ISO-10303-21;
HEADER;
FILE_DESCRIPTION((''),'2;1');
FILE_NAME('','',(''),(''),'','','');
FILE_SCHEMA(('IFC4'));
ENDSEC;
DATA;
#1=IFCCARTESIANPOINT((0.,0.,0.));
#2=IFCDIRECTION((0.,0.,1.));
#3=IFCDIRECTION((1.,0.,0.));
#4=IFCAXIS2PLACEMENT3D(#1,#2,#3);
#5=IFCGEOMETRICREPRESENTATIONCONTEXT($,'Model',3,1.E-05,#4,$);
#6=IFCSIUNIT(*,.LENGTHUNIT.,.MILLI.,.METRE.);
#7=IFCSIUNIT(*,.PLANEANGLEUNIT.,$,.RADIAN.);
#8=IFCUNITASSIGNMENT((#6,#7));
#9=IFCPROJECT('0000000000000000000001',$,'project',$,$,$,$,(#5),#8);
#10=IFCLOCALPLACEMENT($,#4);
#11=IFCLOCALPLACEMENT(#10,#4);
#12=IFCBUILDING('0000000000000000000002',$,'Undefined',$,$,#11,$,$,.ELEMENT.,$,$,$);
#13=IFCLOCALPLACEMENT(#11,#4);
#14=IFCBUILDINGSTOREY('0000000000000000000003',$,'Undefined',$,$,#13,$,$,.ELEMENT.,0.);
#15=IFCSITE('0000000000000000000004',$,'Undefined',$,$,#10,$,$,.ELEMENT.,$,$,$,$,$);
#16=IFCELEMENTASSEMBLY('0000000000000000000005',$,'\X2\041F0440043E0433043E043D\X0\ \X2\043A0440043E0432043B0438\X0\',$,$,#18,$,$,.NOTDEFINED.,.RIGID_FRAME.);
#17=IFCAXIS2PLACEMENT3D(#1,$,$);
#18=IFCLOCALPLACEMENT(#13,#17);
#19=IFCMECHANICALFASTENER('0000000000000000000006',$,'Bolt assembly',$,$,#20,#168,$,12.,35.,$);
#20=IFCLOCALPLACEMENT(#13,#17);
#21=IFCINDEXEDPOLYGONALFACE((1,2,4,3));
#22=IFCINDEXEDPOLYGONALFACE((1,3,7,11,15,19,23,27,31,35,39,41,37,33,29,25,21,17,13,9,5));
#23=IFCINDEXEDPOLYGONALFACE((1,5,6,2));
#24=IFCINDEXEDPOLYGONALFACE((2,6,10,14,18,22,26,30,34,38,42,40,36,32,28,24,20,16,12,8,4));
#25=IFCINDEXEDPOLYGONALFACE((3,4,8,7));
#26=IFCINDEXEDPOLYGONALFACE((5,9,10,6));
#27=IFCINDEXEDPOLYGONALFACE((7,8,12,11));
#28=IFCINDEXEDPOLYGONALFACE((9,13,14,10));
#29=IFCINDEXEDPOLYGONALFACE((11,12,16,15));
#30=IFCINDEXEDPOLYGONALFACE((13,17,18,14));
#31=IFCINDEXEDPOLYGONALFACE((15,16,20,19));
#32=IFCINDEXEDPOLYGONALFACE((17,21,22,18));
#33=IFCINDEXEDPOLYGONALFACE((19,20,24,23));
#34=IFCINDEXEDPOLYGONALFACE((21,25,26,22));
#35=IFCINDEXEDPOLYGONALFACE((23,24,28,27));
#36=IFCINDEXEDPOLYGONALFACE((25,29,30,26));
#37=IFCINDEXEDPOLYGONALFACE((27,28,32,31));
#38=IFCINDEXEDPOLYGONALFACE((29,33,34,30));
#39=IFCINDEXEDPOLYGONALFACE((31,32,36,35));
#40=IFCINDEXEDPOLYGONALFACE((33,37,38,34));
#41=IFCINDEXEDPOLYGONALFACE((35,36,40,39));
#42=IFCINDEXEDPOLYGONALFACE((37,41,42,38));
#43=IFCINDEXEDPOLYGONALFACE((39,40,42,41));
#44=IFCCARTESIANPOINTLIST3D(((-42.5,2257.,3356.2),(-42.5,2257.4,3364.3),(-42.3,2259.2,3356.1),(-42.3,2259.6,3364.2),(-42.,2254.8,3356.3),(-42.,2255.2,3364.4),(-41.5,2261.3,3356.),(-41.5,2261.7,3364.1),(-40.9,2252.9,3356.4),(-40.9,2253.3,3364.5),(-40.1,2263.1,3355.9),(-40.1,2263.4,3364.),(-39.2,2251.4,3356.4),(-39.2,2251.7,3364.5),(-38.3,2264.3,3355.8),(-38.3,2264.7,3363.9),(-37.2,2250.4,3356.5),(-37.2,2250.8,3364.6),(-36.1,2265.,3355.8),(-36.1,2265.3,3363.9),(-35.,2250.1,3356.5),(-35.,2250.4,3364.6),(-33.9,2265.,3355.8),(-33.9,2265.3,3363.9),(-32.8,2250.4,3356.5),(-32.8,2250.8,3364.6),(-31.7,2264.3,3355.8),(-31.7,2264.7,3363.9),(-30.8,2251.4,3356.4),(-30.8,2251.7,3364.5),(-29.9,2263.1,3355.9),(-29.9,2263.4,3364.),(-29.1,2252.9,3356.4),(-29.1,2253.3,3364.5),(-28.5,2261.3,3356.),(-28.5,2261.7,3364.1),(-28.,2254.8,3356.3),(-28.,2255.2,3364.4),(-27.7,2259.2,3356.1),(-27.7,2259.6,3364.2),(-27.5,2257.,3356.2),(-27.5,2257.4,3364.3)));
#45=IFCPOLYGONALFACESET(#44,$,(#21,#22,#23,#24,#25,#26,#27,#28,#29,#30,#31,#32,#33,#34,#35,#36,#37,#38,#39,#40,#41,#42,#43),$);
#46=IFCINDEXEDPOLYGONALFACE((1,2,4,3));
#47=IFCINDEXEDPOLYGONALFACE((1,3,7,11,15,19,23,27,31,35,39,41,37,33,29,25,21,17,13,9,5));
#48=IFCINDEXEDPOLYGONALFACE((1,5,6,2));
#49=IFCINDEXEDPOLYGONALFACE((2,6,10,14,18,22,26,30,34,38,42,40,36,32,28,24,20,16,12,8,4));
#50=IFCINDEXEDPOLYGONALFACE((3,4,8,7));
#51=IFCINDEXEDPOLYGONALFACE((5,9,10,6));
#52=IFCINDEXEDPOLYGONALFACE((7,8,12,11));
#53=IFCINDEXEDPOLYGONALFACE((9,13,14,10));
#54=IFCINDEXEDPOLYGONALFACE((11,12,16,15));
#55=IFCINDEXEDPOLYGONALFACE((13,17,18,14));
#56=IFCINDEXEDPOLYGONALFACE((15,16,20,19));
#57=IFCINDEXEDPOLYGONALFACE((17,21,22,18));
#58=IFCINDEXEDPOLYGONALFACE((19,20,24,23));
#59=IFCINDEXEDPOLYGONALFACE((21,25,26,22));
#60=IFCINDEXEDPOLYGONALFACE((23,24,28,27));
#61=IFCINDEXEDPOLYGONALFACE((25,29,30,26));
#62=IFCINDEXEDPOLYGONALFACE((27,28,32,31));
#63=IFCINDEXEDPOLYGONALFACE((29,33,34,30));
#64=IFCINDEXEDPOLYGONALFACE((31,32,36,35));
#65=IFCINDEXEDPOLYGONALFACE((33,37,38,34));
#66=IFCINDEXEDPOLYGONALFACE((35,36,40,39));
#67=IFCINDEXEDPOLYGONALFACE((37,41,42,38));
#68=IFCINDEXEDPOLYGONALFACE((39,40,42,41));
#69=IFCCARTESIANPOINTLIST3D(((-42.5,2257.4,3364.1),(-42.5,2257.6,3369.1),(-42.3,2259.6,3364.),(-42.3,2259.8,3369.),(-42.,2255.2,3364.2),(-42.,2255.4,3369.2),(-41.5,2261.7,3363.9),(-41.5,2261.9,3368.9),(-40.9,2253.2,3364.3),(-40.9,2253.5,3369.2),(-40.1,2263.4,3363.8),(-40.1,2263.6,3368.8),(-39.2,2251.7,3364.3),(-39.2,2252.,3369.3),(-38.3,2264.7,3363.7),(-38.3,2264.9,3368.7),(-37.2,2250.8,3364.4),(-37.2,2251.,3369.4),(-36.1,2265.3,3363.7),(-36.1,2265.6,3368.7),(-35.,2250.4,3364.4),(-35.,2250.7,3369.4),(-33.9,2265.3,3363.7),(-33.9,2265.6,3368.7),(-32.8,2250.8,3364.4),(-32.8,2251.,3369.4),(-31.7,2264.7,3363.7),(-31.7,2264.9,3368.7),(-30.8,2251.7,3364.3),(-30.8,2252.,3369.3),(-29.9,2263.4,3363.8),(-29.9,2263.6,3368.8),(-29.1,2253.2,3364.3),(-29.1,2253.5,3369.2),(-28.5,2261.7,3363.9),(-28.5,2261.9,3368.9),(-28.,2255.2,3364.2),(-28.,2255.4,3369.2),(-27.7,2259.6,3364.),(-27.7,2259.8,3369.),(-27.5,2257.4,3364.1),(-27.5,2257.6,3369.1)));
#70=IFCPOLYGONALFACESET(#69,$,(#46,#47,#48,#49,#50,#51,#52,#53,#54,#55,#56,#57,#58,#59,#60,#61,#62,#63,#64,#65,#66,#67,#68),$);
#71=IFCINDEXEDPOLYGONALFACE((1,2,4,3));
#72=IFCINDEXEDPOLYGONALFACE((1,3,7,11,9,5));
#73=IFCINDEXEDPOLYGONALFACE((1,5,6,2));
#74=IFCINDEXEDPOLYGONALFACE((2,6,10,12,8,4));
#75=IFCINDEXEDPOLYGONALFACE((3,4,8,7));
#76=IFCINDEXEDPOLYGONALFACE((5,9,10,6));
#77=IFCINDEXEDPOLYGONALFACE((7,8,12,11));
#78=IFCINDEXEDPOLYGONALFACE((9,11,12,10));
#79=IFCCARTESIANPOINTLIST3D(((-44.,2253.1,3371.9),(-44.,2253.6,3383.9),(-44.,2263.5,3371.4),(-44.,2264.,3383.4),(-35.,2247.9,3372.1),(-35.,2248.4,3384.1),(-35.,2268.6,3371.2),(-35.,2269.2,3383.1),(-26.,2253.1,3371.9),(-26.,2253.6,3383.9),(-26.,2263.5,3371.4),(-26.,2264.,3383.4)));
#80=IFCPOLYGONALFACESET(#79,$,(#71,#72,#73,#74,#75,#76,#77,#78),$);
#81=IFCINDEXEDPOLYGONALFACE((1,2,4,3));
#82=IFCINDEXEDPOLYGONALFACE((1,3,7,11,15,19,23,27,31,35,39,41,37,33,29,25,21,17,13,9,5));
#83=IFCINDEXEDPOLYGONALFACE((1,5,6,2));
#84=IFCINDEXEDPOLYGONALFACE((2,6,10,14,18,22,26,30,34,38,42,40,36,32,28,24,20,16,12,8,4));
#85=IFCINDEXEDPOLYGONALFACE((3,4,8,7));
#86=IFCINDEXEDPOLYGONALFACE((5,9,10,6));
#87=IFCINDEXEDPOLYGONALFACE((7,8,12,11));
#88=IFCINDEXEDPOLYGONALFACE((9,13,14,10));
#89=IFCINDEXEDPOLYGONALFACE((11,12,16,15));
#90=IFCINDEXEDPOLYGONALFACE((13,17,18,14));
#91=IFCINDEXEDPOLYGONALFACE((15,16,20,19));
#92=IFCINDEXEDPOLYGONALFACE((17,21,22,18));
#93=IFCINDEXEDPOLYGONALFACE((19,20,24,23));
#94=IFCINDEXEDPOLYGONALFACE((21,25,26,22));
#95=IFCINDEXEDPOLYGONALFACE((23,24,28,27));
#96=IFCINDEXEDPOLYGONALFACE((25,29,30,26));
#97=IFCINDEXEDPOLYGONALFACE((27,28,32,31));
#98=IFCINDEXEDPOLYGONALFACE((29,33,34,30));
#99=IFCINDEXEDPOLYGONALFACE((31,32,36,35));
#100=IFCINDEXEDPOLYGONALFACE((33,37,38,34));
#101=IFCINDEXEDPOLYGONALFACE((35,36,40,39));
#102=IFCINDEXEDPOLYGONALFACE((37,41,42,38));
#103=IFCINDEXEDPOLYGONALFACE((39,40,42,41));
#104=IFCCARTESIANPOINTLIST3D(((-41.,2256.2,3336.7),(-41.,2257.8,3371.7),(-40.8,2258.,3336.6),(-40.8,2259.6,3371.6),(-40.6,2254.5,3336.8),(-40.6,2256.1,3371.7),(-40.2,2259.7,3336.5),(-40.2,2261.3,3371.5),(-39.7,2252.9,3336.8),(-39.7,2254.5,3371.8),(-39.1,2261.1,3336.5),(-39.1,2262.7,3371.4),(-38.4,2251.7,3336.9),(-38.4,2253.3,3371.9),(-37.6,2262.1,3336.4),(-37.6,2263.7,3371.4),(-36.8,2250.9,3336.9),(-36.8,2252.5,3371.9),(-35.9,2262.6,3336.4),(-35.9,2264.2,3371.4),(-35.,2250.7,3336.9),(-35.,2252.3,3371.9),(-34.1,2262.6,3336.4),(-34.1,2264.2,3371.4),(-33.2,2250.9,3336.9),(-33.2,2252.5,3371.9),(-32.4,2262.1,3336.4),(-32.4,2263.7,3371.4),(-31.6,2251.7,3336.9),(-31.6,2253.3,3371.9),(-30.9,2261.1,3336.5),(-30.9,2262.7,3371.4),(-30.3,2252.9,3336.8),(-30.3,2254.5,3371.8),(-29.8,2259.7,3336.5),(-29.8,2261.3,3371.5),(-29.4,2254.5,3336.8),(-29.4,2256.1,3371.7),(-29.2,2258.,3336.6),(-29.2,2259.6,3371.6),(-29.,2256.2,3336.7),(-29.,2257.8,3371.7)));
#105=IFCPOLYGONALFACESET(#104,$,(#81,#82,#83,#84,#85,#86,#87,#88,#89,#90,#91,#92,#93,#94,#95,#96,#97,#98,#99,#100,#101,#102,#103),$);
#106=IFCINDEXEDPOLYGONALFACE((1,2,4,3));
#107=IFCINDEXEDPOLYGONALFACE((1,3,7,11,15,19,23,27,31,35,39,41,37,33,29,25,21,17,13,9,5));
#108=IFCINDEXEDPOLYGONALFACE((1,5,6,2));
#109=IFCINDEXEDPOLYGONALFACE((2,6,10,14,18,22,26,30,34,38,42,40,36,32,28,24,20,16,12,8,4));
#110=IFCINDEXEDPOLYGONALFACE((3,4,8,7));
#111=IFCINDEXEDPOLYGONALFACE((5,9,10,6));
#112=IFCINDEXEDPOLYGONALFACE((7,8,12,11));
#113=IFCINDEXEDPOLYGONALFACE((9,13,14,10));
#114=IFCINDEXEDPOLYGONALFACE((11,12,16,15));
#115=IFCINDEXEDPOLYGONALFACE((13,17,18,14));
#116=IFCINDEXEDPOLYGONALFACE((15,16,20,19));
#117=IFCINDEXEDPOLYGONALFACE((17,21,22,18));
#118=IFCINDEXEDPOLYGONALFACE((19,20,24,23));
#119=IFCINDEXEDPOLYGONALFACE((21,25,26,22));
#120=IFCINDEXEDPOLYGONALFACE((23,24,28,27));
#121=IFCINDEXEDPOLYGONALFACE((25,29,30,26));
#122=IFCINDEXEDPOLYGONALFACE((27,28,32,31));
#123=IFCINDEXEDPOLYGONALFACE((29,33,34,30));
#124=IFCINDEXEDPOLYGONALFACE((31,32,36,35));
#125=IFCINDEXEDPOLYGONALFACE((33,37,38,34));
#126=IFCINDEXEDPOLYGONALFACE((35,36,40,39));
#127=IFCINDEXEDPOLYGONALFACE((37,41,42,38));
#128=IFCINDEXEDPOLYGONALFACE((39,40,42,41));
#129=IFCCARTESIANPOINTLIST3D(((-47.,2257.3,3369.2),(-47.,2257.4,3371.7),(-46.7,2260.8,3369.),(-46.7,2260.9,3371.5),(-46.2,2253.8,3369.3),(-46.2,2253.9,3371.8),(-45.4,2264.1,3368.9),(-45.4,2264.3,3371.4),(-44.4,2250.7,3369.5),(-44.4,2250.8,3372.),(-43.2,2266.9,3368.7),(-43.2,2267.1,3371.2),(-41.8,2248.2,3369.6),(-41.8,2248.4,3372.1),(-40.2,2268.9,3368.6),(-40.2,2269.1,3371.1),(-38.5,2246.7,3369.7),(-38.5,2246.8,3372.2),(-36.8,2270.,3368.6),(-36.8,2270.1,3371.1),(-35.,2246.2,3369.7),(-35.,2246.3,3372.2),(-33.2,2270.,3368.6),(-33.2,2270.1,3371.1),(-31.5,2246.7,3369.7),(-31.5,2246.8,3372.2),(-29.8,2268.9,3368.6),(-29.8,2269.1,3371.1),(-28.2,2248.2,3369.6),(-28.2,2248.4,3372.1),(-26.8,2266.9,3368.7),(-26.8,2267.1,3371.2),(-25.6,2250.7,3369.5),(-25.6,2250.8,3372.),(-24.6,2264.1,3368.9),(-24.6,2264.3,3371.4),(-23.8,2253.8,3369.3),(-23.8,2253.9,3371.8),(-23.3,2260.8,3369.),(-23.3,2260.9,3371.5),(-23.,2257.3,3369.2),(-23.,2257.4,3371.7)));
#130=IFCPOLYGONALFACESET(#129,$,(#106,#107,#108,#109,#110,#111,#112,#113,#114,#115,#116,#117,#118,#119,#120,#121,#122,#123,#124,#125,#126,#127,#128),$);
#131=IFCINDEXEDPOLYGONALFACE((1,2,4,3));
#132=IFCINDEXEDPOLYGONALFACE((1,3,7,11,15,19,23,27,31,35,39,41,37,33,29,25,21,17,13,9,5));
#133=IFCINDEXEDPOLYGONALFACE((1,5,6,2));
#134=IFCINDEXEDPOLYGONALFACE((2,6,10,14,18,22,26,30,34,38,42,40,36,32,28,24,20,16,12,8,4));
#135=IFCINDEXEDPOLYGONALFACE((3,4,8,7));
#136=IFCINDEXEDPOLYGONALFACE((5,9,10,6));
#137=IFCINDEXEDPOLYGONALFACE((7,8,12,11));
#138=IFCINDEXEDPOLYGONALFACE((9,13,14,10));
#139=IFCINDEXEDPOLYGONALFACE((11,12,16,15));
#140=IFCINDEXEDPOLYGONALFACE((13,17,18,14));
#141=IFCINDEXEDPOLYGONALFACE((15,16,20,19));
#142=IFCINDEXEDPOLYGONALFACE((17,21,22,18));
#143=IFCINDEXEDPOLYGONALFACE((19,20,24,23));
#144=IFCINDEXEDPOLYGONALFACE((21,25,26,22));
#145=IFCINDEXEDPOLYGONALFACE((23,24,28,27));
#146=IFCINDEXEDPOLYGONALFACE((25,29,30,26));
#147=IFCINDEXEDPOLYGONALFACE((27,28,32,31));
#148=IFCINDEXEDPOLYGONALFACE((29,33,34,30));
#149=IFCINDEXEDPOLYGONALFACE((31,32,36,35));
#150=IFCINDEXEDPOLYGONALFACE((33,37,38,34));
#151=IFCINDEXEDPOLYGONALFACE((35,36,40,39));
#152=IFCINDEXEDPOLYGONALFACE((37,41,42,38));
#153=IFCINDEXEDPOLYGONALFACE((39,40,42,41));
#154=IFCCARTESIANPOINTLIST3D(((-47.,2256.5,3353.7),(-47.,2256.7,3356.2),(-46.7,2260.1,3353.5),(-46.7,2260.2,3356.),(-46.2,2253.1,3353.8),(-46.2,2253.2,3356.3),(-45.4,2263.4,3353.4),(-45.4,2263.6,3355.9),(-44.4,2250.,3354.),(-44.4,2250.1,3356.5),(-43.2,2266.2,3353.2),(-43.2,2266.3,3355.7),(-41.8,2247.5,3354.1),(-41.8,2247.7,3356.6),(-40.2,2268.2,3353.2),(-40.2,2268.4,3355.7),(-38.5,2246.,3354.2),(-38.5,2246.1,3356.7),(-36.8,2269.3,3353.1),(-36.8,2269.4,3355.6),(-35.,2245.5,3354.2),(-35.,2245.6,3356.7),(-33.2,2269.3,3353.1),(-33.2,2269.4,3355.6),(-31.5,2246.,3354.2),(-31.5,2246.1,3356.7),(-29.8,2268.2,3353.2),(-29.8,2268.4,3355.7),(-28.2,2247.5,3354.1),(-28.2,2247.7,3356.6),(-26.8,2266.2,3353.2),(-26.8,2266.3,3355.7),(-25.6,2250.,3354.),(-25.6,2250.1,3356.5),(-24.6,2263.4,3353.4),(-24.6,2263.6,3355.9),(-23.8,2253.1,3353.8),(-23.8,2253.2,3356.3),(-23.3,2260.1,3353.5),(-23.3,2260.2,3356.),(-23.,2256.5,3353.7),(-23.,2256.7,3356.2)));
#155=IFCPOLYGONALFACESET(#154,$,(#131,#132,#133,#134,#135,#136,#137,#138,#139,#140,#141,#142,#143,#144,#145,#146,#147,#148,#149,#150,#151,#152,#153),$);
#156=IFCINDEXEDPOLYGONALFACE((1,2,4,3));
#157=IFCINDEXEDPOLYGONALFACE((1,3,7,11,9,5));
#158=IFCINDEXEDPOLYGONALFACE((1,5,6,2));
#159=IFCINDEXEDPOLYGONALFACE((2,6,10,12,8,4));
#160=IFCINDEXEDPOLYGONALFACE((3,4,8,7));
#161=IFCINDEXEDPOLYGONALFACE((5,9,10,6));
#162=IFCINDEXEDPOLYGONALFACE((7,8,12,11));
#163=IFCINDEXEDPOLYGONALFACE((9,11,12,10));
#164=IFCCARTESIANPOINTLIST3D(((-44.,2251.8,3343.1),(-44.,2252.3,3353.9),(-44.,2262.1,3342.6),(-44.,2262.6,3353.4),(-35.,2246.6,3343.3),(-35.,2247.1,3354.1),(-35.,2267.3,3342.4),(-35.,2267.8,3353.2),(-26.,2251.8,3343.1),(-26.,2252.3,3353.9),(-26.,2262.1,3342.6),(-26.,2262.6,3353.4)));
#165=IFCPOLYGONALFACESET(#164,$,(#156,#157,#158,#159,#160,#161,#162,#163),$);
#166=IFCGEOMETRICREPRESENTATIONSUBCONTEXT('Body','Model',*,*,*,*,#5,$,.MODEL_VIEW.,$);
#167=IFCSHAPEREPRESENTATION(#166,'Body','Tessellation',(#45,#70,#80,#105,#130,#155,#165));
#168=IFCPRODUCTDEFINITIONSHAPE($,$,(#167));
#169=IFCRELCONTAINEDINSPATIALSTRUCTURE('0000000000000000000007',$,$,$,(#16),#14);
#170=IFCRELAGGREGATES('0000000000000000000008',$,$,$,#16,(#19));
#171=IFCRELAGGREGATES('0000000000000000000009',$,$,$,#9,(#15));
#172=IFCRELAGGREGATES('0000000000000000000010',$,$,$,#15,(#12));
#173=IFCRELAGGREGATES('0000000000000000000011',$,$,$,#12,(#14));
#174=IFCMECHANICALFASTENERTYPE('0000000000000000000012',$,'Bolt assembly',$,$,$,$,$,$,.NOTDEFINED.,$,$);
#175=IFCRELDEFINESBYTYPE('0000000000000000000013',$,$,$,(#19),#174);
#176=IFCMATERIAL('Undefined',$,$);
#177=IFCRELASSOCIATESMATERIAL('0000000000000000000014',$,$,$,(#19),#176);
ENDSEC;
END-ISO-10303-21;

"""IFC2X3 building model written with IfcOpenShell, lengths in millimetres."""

from ifc_helpers import new_model, si_unit, frame, origin_with_axes, origin_2d_with_axis, place, context, subcontext, project, spatial, polyline, circle, outline, extrude, source, transform, mapped, material, type_object, element, aggregate, save


model = new_model("IFC2X3")

# Units and contexts
model_context = context("Model", 3, precision=1e-05, world=origin_with_axes())
body_context = subcontext(model_context, "Body", "Model", "MODEL_VIEW")
ifc_project = project(units=[si_unit("LENGTHUNIT", "METRE", prefix="MILLI"), si_unit("PLANEANGLEUNIT", "RADIAN")], contexts=[model_context])

# Site, building, storey
site_placement = place(None, origin_with_axes())
site = spatial("IfcSite", under=ifc_project, at=site_placement, Name="Undefined", CompositionType="ELEMENT")
building_placement = place(site_placement, origin_with_axes())
building = spatial("IfcBuilding", under=site, at=building_placement, Name="Undefined", CompositionType="ELEMENT")
storey_placement = place(building_placement, origin_with_axes())
storey = spatial("IfcBuildingStorey", under=building, at=storey_placement, Name="Undefined", CompositionType="ELEMENT", Elevation=0.0)

# Element assembly
assembly_1_placement = place(storey_placement, origin_with_axes())
assembly_1 = element("IfcElementAssembly", 1, at=assembly_1_placement, inside=storey, Name="Прогон кровли", AssemblyPlace="NOTDEFINED", PredefinedType="RIGID_FRAME")

# Mechanical fastener
ifc_material_1 = material(Name="Undefined")
mechanical_fastener_type = type_object("IfcMechanicalFastenerType", Name="Bolt assembly")
shared_shape_1 = source(origin_with_axes(), body_context, "Body", "SweptSolid", [
    extrude(circle(Radius=7.5, at=origin_2d_with_axis()), frame((0.0, -0.1, 0.0), z_axis=(0.0, 1.0, 0.0), x_axis=(1.0, 0.0, 0.0)), (0.0, 0.0, 1.0), 8.1),
    extrude(circle(Radius=7.5, at=origin_2d_with_axis()), frame((0.0, -4.9, 0.0), z_axis=(0.0, 1.0, 0.0), x_axis=(1.0, 0.0, 0.0)), (0.0, 0.0, 1.0), 5.0),
    extrude(outline(polyline([(10.4, 0.0), (5.2, 9.0), (-5.2, 9.0), (-10.4, 0.0), (-5.2, -9.0), (5.2, -9.0), (10.4, 0.0)])), frame((0.0, -19.5, 0.0), z_axis=(0.0, 1.0, 0.0), x_axis=(1.0, 0.0, 0.0)), (0.0, 0.0, 1.0), 12.0),
    extrude(circle(Radius=6.0, at=origin_2d_with_axis()), frame((0.0, -7.5, 0.0), z_axis=(0.0, 1.0, 0.0), x_axis=(1.0, 0.0, 0.0)), (0.0, 0.0, 1.0), 35.0),
    extrude(circle(Radius=12.0, at=origin_2d_with_axis()), frame((0.0, -7.5, 0.0), z_axis=(0.0, 1.0, 0.0), x_axis=(1.0, 0.0, 0.0)), (0.0, 0.0, 1.0), 2.5),
    extrude(circle(Radius=12.0, at=origin_2d_with_axis()), frame((0.0, 8.0, 0.0), z_axis=(0.0, 1.0, 0.0), x_axis=(1.0, 0.0, 0.0)), (0.0, 0.0, 1.0), 2.5),
    extrude(outline(polyline([(10.4, 0.0), (5.2, 9.0), (-5.2, 9.0), (-10.4, 0.0), (-5.2, -9.0), (5.2, -9.0), (10.4, 0.0)])), frame((0.0, 10.5, 0.0), z_axis=(0.0, 1.0, 0.0), x_axis=(1.0, 0.0, 0.0)), (0.0, 0.0, 1.0), 10.8),
])
mechanical_fastener_1_placement = place(assembly_1_placement, frame((-35.0, 2257.9, 3364.1), z_axis=(1.0, 0.0, 0.0), x_axis=(0.0, -0.998969, 0.045408)))
mechanical_fastener_1 = element("IfcMechanicalFastener", 2, at=mechanical_fastener_1_placement, type_object=mechanical_fastener_type, material=ifc_material_1, Name="Bolt assembly", NominalDiameter=12.0, NominalLength=35.0, context=body_context, shape_type="MappedRepresentation", body=[
    mapped(shared_shape_1, transform((0.0, 0.0, 0.0))),
])
aggregate(assembly_1, [mechanical_fastener_1])

save(model, "model.ifc")
